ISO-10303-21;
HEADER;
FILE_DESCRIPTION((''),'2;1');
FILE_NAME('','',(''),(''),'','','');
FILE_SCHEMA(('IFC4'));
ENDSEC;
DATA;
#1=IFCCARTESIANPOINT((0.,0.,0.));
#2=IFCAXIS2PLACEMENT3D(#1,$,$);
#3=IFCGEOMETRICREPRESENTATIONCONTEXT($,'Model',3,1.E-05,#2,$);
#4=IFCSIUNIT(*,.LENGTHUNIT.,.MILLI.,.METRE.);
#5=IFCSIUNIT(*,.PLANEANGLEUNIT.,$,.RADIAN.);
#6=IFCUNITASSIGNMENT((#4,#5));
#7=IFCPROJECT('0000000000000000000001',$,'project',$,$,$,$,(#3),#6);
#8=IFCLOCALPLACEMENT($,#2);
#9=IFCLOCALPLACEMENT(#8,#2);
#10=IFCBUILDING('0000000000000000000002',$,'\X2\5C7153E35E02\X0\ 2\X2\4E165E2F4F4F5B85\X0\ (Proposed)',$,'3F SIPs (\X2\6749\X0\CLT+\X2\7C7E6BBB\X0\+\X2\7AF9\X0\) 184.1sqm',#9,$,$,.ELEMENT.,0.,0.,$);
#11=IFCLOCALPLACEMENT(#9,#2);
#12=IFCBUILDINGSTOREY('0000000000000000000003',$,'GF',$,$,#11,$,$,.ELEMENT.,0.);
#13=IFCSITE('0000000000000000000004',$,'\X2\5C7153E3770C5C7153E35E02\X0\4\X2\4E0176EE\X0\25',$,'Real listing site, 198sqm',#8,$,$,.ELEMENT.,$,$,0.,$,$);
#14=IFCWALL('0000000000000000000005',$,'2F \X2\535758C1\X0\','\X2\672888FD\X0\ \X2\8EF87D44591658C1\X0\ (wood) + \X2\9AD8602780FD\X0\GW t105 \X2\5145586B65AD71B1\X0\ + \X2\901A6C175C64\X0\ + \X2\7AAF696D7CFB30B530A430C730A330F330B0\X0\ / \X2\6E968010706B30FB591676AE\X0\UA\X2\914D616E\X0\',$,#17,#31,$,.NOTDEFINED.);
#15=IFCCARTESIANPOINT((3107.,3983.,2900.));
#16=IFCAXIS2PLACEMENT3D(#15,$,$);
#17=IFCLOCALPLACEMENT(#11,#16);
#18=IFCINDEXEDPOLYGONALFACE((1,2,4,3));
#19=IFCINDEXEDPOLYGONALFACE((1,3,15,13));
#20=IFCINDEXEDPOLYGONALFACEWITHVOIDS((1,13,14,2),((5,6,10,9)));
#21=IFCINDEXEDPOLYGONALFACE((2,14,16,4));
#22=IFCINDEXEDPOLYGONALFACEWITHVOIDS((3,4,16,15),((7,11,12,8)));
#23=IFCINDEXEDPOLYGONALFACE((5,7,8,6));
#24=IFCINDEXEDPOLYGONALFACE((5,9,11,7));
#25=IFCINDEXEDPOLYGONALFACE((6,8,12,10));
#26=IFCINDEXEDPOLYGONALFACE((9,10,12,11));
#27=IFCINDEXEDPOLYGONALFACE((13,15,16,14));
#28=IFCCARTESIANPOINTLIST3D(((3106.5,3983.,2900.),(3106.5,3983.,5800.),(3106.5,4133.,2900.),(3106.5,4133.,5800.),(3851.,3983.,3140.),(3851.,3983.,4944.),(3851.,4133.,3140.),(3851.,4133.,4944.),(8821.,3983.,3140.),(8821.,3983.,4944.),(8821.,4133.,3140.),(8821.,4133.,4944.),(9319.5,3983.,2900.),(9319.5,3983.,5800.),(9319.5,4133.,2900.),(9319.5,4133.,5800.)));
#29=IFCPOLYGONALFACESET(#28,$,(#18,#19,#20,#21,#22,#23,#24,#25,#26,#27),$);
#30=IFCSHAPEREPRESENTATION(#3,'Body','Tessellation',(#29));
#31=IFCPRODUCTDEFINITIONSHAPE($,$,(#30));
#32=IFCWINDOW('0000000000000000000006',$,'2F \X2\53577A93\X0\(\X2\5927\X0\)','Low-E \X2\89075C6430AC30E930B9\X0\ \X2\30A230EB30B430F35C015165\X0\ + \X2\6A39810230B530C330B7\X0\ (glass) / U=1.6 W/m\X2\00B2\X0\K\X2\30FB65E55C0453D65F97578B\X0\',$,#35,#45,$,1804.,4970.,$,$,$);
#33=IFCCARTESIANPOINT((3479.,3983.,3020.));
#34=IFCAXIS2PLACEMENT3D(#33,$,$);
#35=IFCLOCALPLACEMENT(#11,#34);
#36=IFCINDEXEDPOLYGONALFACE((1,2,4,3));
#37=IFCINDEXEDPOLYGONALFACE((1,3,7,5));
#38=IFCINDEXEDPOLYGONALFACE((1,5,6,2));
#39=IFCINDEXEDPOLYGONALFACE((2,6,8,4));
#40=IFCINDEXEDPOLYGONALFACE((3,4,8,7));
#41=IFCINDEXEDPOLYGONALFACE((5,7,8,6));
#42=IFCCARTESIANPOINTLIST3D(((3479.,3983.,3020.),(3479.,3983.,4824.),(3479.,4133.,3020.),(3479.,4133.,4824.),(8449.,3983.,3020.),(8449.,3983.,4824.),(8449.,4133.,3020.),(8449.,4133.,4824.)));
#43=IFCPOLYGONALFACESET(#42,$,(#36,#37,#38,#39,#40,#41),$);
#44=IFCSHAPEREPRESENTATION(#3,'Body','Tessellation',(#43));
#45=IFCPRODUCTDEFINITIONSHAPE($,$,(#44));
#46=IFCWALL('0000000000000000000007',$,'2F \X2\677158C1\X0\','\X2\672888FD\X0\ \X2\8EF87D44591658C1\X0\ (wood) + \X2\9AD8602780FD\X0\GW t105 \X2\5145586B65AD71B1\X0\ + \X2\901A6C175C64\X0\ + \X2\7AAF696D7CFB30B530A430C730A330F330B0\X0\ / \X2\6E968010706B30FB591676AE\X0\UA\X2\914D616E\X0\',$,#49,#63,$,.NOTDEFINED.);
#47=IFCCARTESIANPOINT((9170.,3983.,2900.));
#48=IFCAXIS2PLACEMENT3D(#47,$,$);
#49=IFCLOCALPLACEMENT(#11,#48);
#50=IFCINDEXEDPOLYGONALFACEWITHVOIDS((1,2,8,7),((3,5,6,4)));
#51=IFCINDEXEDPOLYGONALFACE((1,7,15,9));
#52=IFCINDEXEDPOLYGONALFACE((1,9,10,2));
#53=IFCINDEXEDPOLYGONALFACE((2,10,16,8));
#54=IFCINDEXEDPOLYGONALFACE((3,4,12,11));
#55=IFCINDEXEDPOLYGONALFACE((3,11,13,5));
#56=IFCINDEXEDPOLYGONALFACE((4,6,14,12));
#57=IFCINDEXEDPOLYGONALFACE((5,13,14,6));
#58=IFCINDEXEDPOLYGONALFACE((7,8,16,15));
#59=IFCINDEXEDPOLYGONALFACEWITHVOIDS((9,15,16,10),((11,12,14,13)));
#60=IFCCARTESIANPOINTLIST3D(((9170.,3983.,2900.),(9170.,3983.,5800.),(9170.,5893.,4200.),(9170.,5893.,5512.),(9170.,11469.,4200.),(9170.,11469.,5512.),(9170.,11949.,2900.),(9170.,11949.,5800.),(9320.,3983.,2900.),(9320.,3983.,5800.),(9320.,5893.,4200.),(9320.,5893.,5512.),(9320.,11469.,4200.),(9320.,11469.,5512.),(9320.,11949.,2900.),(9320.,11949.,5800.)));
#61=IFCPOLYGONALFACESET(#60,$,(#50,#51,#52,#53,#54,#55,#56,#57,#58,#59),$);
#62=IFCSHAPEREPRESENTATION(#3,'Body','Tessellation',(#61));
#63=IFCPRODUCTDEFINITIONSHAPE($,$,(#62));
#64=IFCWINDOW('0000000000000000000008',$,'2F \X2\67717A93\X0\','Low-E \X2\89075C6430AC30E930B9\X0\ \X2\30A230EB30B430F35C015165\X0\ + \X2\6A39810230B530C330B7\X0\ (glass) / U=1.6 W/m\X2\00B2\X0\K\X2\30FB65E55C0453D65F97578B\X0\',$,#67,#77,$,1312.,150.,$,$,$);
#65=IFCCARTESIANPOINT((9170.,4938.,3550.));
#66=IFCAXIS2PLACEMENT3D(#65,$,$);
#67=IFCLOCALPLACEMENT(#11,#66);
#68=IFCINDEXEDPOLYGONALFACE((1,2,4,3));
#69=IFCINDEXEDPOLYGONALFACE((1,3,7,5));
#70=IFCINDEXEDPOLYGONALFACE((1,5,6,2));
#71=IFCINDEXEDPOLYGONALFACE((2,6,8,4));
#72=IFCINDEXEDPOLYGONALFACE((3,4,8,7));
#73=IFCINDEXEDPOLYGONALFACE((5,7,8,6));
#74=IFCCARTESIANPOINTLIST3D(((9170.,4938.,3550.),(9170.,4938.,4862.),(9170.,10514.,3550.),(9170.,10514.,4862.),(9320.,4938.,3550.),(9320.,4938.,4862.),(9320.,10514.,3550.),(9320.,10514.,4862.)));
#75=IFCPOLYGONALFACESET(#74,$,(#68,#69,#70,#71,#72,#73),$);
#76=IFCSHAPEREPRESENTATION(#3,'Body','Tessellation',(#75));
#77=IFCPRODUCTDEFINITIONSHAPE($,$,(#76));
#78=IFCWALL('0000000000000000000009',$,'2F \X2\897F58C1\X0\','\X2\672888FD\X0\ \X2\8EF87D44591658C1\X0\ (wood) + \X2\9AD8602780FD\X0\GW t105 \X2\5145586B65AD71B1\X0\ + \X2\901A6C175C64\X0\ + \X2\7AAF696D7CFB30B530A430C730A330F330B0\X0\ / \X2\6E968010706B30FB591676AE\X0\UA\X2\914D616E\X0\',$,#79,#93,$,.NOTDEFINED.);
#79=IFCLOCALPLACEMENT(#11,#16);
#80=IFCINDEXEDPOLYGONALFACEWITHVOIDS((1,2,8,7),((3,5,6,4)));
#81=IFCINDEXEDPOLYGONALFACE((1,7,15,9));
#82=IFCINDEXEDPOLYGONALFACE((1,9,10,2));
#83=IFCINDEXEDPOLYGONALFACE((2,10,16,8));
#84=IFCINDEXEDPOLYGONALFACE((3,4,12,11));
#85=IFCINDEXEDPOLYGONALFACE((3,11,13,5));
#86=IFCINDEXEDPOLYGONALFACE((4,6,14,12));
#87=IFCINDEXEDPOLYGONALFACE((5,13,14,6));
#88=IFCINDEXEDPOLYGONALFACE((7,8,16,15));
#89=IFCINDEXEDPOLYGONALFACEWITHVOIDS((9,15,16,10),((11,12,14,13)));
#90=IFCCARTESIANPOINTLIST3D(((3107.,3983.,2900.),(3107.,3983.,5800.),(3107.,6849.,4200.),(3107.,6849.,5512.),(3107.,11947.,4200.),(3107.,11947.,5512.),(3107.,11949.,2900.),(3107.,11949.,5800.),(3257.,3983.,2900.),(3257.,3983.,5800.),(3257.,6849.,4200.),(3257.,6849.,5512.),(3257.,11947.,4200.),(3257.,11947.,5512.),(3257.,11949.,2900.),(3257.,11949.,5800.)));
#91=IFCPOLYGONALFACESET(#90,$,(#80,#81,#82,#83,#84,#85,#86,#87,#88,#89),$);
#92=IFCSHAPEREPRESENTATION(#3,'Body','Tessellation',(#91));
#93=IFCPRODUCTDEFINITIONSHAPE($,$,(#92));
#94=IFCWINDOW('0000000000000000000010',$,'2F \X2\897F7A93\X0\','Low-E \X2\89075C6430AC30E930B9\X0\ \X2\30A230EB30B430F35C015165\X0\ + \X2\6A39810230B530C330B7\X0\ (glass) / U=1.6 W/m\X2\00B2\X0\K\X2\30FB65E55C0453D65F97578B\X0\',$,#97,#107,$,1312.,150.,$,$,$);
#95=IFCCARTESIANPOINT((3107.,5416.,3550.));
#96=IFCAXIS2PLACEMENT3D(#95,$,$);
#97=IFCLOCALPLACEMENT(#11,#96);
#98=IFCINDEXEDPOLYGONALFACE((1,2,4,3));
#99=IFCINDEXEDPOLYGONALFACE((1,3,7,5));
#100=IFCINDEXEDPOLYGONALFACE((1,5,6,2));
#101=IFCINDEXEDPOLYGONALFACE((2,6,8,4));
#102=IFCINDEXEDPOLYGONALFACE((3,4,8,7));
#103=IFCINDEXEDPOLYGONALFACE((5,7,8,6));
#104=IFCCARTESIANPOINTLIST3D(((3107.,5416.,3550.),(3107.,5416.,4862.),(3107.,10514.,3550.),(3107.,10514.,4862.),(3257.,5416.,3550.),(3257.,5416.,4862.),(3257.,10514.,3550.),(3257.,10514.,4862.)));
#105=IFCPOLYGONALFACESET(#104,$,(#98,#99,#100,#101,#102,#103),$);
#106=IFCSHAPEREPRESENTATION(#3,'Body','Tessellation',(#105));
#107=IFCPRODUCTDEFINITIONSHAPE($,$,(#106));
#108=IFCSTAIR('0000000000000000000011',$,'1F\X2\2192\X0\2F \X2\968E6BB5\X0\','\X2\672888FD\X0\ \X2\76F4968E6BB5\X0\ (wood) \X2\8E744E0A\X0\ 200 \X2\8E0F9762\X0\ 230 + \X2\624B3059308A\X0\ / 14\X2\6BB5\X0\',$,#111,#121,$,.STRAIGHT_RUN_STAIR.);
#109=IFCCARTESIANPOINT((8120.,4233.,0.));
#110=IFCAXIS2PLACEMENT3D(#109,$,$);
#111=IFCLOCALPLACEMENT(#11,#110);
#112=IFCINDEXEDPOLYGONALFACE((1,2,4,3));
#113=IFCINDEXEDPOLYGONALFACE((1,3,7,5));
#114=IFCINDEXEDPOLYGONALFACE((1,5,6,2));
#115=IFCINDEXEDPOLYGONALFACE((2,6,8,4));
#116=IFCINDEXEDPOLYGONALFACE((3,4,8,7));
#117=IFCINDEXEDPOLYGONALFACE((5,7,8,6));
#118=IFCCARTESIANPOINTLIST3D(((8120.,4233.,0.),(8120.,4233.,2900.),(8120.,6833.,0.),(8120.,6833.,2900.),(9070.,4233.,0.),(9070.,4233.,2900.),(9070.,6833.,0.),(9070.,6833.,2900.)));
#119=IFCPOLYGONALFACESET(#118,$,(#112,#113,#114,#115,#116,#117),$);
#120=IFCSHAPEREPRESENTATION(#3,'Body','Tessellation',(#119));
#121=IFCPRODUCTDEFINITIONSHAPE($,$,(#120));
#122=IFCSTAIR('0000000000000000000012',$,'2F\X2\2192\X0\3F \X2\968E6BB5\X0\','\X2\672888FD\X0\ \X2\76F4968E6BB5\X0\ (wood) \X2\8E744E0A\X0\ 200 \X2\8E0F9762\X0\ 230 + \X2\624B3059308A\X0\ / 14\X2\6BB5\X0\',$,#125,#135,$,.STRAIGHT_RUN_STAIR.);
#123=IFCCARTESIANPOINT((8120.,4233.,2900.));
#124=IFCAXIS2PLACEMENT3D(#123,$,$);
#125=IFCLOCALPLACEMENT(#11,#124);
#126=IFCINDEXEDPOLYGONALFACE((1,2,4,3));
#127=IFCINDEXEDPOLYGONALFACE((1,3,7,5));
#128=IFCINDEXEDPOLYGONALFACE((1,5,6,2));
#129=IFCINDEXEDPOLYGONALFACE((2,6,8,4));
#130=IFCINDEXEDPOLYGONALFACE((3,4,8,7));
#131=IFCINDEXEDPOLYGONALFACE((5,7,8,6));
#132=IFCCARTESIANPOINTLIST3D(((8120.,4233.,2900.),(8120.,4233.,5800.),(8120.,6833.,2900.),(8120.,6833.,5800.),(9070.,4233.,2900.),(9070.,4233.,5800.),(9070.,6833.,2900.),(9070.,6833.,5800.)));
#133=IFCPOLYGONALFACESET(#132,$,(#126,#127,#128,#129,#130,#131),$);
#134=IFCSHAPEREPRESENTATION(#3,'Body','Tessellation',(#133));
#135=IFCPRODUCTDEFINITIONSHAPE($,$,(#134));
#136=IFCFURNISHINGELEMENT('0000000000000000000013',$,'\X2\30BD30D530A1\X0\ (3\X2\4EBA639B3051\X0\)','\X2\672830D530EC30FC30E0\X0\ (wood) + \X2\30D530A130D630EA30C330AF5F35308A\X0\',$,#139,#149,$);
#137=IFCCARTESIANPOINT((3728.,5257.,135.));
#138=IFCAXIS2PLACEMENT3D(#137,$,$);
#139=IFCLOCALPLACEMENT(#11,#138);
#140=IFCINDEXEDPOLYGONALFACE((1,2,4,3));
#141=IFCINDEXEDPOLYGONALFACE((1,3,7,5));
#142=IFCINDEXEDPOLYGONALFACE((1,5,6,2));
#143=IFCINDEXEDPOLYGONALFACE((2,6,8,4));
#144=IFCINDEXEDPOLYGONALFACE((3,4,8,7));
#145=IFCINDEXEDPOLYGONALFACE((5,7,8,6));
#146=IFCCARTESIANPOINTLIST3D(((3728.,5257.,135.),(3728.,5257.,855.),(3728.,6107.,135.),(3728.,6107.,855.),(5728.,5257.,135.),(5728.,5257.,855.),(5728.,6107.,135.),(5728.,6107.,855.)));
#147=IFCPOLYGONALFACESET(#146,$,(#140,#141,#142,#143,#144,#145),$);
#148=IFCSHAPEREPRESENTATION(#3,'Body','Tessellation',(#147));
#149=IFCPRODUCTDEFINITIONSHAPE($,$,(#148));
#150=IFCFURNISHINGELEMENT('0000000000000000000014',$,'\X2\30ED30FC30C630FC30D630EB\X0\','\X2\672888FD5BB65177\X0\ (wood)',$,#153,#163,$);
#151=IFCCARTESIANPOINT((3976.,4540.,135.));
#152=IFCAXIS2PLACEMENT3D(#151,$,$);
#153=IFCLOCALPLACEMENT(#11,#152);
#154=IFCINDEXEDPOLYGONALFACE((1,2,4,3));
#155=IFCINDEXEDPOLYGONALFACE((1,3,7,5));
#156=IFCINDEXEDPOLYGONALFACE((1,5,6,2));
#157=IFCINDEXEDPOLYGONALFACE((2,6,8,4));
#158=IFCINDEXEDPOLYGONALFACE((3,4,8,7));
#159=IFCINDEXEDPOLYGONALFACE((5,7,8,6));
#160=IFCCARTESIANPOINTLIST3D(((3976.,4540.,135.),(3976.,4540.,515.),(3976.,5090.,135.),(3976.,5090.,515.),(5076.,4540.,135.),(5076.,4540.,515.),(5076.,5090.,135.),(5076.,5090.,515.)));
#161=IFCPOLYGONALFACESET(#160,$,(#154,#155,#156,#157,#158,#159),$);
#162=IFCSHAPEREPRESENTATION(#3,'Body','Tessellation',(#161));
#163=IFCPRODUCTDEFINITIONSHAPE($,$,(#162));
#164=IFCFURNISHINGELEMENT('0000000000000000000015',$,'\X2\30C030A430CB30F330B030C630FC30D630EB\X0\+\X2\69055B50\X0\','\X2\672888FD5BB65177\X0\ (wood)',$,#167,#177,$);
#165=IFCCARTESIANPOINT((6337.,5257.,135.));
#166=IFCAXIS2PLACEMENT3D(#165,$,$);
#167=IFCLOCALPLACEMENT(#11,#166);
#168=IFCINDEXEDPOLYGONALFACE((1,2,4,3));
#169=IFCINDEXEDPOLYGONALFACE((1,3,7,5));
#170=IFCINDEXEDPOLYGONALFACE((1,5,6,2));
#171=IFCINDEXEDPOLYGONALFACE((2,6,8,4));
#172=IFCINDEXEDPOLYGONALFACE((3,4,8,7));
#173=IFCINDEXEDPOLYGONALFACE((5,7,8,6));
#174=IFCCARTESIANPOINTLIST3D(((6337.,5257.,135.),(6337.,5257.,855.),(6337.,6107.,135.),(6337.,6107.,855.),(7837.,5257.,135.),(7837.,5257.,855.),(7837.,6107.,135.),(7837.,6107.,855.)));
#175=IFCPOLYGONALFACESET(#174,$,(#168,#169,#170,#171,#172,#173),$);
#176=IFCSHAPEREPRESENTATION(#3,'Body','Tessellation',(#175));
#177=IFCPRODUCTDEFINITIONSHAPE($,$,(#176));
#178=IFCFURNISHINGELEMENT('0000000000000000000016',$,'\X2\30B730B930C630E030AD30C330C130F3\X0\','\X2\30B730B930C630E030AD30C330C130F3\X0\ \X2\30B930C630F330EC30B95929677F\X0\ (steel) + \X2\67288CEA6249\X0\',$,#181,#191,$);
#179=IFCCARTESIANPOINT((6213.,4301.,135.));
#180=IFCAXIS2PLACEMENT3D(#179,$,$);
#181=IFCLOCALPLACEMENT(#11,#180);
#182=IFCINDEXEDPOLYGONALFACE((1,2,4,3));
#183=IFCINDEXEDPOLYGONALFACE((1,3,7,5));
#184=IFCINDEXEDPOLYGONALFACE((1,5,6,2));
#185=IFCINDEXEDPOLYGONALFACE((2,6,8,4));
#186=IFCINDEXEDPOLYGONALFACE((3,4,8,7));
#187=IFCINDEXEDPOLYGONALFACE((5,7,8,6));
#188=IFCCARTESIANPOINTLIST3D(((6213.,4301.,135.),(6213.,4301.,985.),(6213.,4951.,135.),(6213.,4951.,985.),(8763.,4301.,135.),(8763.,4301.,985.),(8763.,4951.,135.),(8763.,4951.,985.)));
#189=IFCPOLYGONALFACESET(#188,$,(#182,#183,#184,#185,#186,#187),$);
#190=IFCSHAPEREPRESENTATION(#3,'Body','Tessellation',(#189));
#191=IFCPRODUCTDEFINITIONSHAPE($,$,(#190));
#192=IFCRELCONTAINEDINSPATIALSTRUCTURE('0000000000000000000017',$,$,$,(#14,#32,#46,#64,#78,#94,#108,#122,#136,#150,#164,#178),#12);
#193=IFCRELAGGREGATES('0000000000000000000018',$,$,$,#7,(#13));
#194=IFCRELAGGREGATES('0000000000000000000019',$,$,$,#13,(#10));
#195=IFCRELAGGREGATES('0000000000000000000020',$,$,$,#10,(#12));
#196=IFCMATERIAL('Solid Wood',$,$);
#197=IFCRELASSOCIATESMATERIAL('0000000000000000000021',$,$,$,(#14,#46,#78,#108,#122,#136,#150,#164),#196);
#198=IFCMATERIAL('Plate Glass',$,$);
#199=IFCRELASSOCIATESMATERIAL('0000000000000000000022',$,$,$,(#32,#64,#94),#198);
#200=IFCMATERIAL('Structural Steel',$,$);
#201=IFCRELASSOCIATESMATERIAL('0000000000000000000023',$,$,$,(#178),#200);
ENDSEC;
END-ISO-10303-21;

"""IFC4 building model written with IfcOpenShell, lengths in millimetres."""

from ifc_helpers import new_model, si_unit, frame, frame_2d, origin, place, context, project, spatial, rectangle, extrude, material, element, fill, save


model = new_model("IFC4")

# Units and contexts
model_context = context("Model", 3, precision=1e-05, world=origin())
ifc_project = project(units=[si_unit("LENGTHUNIT", "METRE", prefix="MILLI"), si_unit("PLANEANGLEUNIT", "RADIAN")], contexts=[model_context])

# Site, building, storey
site_placement = place(None, origin())
site = spatial("IfcSite", under=ifc_project, at=site_placement, Name="山口県山口市4丁目25", ObjectType="Real listing site, 198sqm", CompositionType="ELEMENT", RefElevation=0.0)
building_placement = place(site_placement, origin())
building = spatial("IfcBuilding", under=site, at=building_placement, Name="山口市 2世帯住宅 (Proposed)", ObjectType="3F SIPs (杉CLT+籾殻+竹) 184.1sqm", CompositionType="ELEMENT", ElevationOfRefHeight=0.0, ElevationOfTerrain=0.0)
storey_placement = place(building_placement, origin())
storey = spatial("IfcBuildingStorey", under=building, at=storey_placement, Name="GF", CompositionType="ELEMENT", Elevation=0.0)

# Shared definitions
ifc_material_1 = material(Name="Solid Wood")

# Shared definitions
ifc_material_2 = material(Name="Plate Glass")

# Walls, openings, windows
wall_1_placement = place(storey_placement, frame((3107.0, 3983.0, 2900.0)))
wall_1 = element("IfcWall", 1, at=wall_1_placement, inside=storey, material=ifc_material_1, Name="2F 南壁", Description="木製 軸組外壁 (wood) + 高性能GW t105 充填断熱 + 通気層 + 窯業系サイディング / 準耐火・外皮UA配慮", PredefinedType="NOTDEFINED", context=model_context, shape_type="SweptSolid", body=[
    extrude(rectangle(XDim=6213.0, YDim=150.0, at=frame_2d((3106.0, 75.0))), frame((3107.0, 3983.0, 2900.0)), (0.0, 0.0, 1.0), 2900.0),
])
opening_1_placement = place(storey_placement, frame((3479.0, 3983.0, 3020.0)))
opening_1 = element("IfcOpeningElement", 2, at=opening_1_placement, cuts=wall_1, PredefinedType="NOTDEFINED", context=model_context, shape_type="SweptSolid", body=[
    extrude(rectangle(XDim=4970.0, YDim=150.0, at=frame_2d((2485.0, 75.0))), frame((3479.0, 3983.0, 3020.0)), (0.0, 0.0, 1.0), 1804.0),
])
window_1_placement = place(storey_placement, frame((3479.0, 3983.0, 3020.0)))
window_1 = element("IfcWindow", 3, at=window_1_placement, inside=storey, material=ifc_material_2, Name="2F 南窓(大)", Description="Low-E 複層ガラス アルゴン封入 + 樹脂サッシ (glass) / U=1.6 W/m²K・日射取得型", OverallHeight=1804.0, OverallWidth=4970.0, context=model_context, shape_type="SweptSolid", body=[
    extrude(rectangle(XDim=4970.0, YDim=150.0, at=frame_2d((2485.0, 75.0))), frame((3479.0, 3983.0, 3020.0)), (0.0, 0.0, 1.0), 1804.0),
])
fill(opening_1, window_1)
wall_2_placement = place(storey_placement, frame((9170.0, 3983.0, 2900.0)))
wall_2 = element("IfcWall", 4, at=wall_2_placement, inside=storey, material=ifc_material_1, Name="2F 東壁", Description="木製 軸組外壁 (wood) + 高性能GW t105 充填断熱 + 通気層 + 窯業系サイディング / 準耐火・外皮UA配慮", PredefinedType="NOTDEFINED", context=model_context, shape_type="SweptSolid", body=[
    extrude(rectangle(XDim=150.0, YDim=7966.0, at=frame_2d((75.0, 3983.0))), frame((9170.0, 3983.0, 2900.0)), (0.0, 0.0, 1.0), 2900.0),
])
opening_2_placement = place(storey_placement, frame((9170.0, 4938.0, 3550.0)))
opening_2 = element("IfcOpeningElement", 5, at=opening_2_placement, cuts=wall_2, PredefinedType="NOTDEFINED", context=model_context, shape_type="SweptSolid", body=[
    extrude(rectangle(XDim=150.0, YDim=5576.0, at=frame_2d((75.0, 2788.0))), frame((9170.0, 4938.0, 3550.0)), (0.0, 0.0, 1.0), 1312.0),
])
window_2_placement = place(storey_placement, frame((9170.0, 4938.0, 3550.0)))
window_2 = element("IfcWindow", 6, at=window_2_placement, inside=storey, material=ifc_material_2, Name="2F 東窓", Description="Low-E 複層ガラス アルゴン封入 + 樹脂サッシ (glass) / U=1.6 W/m²K・日射取得型", OverallHeight=1312.0, OverallWidth=150.0, context=model_context, shape_type="SweptSolid", body=[
    extrude(rectangle(XDim=150.0, YDim=5576.0, at=frame_2d((75.0, 2788.0))), frame((9170.0, 4938.0, 3550.0)), (0.0, 0.0, 1.0), 1312.0),
])
fill(opening_2, window_2)
wall_3_placement = place(storey_placement, frame((3107.0, 3983.0, 2900.0)))
wall_3 = element("IfcWall", 7, at=wall_3_placement, inside=storey, material=ifc_material_1, Name="2F 西壁", Description="木製 軸組外壁 (wood) + 高性能GW t105 充填断熱 + 通気層 + 窯業系サイディング / 準耐火・外皮UA配慮", PredefinedType="NOTDEFINED", context=model_context, shape_type="SweptSolid", body=[
    extrude(rectangle(XDim=150.0, YDim=7966.0, at=frame_2d((75.0, 3983.0))), frame((3107.0, 3983.0, 2900.0)), (0.0, 0.0, 1.0), 2900.0),
])
opening_3_placement = place(storey_placement, frame((3107.0, 5416.0, 3550.0)))
opening_3 = element("IfcOpeningElement", 8, at=opening_3_placement, cuts=wall_3, PredefinedType="NOTDEFINED", context=model_context, shape_type="SweptSolid", body=[
    extrude(rectangle(XDim=150.0, YDim=5098.0, at=frame_2d((75.0, 2549.0))), frame((3107.0, 5416.0, 3550.0)), (0.0, 0.0, 1.0), 1312.0),
])
window_3_placement = place(storey_placement, frame((3107.0, 5416.0, 3550.0)))
window_3 = element("IfcWindow", 9, at=window_3_placement, inside=storey, material=ifc_material_2, Name="2F 西窓", Description="Low-E 複層ガラス アルゴン封入 + 樹脂サッシ (glass) / U=1.6 W/m²K・日射取得型", OverallHeight=1312.0, OverallWidth=150.0, context=model_context, shape_type="SweptSolid", body=[
    extrude(rectangle(XDim=150.0, YDim=5098.0, at=frame_2d((75.0, 2549.0))), frame((3107.0, 5416.0, 3550.0)), (0.0, 0.0, 1.0), 1312.0),
])
fill(opening_3, window_3)

# Stairs
stair_1_placement = place(storey_placement, frame((8120.0, 4233.0, 0.0)))
element("IfcStair", 10, at=stair_1_placement, inside=storey, material=ifc_material_1, Name="1F→2F 階段", Description="木製 直階段 (wood) 蹴上 200 踏面 230 + 手すり / 14段", PredefinedType="STRAIGHT_RUN_STAIR", context=model_context, shape_type="SweptSolid", body=[
    extrude(rectangle(XDim=950.0, YDim=2600.0, at=frame_2d((475.0, 1300.0))), frame((8120.0, 4233.0, 0.0)), (0.0, 0.0, 1.0), 2900.0),
])
stair_2_placement = place(storey_placement, frame((8120.0, 4233.0, 2900.0)))
element("IfcStair", 11, at=stair_2_placement, inside=storey, material=ifc_material_1, Name="2F→3F 階段", Description="木製 直階段 (wood) 蹴上 200 踏面 230 + 手すり / 14段", PredefinedType="STRAIGHT_RUN_STAIR", context=model_context, shape_type="SweptSolid", body=[
    extrude(rectangle(XDim=950.0, YDim=2600.0, at=frame_2d((475.0, 1300.0))), frame((8120.0, 4233.0, 2900.0)), (0.0, 0.0, 1.0), 2900.0),
])

# Furnishing elements
furnishing_1_placement = place(storey_placement, frame((3728.0, 5257.0, 135.0)))
element("IfcFurnishingElement", 12, at=furnishing_1_placement, inside=storey, material=ifc_material_1, Name="ソファ (3人掛け)", Description="木フレーム (wood) + ファブリック張り", context=model_context, shape_type="SweptSolid", body=[
    extrude(rectangle(XDim=2000.0, YDim=850.0, at=frame_2d((1000.0, 425.0))), frame((3728.0, 5257.0, 135.0)), (0.0, 0.0, 1.0), 720.0),
])
furnishing_2_placement = place(storey_placement, frame((3976.0, 4540.0, 135.0)))
element("IfcFurnishingElement", 13, at=furnishing_2_placement, inside=storey, material=ifc_material_1, Name="ローテーブル", Description="木製家具 (wood)", context=model_context, shape_type="SweptSolid", body=[
    extrude(rectangle(XDim=1100.0, YDim=550.0, at=frame_2d((550.0, 275.0))), frame((3976.0, 4540.0, 135.0)), (0.0, 0.0, 1.0), 380.0),
])
furnishing_3_placement = place(storey_placement, frame((6337.0, 5257.0, 135.0)))
element("IfcFurnishingElement", 14, at=furnishing_3_placement, inside=storey, material=ifc_material_1, Name="ダイニングテーブル+椅子", Description="木製家具 (wood)", context=model_context, shape_type="SweptSolid", body=[
    extrude(rectangle(XDim=1500.0, YDim=850.0, at=frame_2d((750.0, 425.0))), frame((6337.0, 5257.0, 135.0)), (0.0, 0.0, 1.0), 720.0),
])
ifc_material_3 = material(Name="Structural Steel")
furnishing_4_placement = place(storey_placement, frame((6213.0, 4301.0, 135.0)))
element("IfcFurnishingElement", 15, at=furnishing_4_placement, inside=storey, material=ifc_material_3, Name="システムキッチン", Description="システムキッチン ステンレス天板 (steel) + 木質扉", context=model_context, shape_type="SweptSolid", body=[
    extrude(rectangle(XDim=2550.0, YDim=650.0, at=frame_2d((1275.0, 325.0))), frame((6213.0, 4301.0, 135.0)), (0.0, 0.0, 1.0), 850.0),
])

save(model, "model.ifc")
